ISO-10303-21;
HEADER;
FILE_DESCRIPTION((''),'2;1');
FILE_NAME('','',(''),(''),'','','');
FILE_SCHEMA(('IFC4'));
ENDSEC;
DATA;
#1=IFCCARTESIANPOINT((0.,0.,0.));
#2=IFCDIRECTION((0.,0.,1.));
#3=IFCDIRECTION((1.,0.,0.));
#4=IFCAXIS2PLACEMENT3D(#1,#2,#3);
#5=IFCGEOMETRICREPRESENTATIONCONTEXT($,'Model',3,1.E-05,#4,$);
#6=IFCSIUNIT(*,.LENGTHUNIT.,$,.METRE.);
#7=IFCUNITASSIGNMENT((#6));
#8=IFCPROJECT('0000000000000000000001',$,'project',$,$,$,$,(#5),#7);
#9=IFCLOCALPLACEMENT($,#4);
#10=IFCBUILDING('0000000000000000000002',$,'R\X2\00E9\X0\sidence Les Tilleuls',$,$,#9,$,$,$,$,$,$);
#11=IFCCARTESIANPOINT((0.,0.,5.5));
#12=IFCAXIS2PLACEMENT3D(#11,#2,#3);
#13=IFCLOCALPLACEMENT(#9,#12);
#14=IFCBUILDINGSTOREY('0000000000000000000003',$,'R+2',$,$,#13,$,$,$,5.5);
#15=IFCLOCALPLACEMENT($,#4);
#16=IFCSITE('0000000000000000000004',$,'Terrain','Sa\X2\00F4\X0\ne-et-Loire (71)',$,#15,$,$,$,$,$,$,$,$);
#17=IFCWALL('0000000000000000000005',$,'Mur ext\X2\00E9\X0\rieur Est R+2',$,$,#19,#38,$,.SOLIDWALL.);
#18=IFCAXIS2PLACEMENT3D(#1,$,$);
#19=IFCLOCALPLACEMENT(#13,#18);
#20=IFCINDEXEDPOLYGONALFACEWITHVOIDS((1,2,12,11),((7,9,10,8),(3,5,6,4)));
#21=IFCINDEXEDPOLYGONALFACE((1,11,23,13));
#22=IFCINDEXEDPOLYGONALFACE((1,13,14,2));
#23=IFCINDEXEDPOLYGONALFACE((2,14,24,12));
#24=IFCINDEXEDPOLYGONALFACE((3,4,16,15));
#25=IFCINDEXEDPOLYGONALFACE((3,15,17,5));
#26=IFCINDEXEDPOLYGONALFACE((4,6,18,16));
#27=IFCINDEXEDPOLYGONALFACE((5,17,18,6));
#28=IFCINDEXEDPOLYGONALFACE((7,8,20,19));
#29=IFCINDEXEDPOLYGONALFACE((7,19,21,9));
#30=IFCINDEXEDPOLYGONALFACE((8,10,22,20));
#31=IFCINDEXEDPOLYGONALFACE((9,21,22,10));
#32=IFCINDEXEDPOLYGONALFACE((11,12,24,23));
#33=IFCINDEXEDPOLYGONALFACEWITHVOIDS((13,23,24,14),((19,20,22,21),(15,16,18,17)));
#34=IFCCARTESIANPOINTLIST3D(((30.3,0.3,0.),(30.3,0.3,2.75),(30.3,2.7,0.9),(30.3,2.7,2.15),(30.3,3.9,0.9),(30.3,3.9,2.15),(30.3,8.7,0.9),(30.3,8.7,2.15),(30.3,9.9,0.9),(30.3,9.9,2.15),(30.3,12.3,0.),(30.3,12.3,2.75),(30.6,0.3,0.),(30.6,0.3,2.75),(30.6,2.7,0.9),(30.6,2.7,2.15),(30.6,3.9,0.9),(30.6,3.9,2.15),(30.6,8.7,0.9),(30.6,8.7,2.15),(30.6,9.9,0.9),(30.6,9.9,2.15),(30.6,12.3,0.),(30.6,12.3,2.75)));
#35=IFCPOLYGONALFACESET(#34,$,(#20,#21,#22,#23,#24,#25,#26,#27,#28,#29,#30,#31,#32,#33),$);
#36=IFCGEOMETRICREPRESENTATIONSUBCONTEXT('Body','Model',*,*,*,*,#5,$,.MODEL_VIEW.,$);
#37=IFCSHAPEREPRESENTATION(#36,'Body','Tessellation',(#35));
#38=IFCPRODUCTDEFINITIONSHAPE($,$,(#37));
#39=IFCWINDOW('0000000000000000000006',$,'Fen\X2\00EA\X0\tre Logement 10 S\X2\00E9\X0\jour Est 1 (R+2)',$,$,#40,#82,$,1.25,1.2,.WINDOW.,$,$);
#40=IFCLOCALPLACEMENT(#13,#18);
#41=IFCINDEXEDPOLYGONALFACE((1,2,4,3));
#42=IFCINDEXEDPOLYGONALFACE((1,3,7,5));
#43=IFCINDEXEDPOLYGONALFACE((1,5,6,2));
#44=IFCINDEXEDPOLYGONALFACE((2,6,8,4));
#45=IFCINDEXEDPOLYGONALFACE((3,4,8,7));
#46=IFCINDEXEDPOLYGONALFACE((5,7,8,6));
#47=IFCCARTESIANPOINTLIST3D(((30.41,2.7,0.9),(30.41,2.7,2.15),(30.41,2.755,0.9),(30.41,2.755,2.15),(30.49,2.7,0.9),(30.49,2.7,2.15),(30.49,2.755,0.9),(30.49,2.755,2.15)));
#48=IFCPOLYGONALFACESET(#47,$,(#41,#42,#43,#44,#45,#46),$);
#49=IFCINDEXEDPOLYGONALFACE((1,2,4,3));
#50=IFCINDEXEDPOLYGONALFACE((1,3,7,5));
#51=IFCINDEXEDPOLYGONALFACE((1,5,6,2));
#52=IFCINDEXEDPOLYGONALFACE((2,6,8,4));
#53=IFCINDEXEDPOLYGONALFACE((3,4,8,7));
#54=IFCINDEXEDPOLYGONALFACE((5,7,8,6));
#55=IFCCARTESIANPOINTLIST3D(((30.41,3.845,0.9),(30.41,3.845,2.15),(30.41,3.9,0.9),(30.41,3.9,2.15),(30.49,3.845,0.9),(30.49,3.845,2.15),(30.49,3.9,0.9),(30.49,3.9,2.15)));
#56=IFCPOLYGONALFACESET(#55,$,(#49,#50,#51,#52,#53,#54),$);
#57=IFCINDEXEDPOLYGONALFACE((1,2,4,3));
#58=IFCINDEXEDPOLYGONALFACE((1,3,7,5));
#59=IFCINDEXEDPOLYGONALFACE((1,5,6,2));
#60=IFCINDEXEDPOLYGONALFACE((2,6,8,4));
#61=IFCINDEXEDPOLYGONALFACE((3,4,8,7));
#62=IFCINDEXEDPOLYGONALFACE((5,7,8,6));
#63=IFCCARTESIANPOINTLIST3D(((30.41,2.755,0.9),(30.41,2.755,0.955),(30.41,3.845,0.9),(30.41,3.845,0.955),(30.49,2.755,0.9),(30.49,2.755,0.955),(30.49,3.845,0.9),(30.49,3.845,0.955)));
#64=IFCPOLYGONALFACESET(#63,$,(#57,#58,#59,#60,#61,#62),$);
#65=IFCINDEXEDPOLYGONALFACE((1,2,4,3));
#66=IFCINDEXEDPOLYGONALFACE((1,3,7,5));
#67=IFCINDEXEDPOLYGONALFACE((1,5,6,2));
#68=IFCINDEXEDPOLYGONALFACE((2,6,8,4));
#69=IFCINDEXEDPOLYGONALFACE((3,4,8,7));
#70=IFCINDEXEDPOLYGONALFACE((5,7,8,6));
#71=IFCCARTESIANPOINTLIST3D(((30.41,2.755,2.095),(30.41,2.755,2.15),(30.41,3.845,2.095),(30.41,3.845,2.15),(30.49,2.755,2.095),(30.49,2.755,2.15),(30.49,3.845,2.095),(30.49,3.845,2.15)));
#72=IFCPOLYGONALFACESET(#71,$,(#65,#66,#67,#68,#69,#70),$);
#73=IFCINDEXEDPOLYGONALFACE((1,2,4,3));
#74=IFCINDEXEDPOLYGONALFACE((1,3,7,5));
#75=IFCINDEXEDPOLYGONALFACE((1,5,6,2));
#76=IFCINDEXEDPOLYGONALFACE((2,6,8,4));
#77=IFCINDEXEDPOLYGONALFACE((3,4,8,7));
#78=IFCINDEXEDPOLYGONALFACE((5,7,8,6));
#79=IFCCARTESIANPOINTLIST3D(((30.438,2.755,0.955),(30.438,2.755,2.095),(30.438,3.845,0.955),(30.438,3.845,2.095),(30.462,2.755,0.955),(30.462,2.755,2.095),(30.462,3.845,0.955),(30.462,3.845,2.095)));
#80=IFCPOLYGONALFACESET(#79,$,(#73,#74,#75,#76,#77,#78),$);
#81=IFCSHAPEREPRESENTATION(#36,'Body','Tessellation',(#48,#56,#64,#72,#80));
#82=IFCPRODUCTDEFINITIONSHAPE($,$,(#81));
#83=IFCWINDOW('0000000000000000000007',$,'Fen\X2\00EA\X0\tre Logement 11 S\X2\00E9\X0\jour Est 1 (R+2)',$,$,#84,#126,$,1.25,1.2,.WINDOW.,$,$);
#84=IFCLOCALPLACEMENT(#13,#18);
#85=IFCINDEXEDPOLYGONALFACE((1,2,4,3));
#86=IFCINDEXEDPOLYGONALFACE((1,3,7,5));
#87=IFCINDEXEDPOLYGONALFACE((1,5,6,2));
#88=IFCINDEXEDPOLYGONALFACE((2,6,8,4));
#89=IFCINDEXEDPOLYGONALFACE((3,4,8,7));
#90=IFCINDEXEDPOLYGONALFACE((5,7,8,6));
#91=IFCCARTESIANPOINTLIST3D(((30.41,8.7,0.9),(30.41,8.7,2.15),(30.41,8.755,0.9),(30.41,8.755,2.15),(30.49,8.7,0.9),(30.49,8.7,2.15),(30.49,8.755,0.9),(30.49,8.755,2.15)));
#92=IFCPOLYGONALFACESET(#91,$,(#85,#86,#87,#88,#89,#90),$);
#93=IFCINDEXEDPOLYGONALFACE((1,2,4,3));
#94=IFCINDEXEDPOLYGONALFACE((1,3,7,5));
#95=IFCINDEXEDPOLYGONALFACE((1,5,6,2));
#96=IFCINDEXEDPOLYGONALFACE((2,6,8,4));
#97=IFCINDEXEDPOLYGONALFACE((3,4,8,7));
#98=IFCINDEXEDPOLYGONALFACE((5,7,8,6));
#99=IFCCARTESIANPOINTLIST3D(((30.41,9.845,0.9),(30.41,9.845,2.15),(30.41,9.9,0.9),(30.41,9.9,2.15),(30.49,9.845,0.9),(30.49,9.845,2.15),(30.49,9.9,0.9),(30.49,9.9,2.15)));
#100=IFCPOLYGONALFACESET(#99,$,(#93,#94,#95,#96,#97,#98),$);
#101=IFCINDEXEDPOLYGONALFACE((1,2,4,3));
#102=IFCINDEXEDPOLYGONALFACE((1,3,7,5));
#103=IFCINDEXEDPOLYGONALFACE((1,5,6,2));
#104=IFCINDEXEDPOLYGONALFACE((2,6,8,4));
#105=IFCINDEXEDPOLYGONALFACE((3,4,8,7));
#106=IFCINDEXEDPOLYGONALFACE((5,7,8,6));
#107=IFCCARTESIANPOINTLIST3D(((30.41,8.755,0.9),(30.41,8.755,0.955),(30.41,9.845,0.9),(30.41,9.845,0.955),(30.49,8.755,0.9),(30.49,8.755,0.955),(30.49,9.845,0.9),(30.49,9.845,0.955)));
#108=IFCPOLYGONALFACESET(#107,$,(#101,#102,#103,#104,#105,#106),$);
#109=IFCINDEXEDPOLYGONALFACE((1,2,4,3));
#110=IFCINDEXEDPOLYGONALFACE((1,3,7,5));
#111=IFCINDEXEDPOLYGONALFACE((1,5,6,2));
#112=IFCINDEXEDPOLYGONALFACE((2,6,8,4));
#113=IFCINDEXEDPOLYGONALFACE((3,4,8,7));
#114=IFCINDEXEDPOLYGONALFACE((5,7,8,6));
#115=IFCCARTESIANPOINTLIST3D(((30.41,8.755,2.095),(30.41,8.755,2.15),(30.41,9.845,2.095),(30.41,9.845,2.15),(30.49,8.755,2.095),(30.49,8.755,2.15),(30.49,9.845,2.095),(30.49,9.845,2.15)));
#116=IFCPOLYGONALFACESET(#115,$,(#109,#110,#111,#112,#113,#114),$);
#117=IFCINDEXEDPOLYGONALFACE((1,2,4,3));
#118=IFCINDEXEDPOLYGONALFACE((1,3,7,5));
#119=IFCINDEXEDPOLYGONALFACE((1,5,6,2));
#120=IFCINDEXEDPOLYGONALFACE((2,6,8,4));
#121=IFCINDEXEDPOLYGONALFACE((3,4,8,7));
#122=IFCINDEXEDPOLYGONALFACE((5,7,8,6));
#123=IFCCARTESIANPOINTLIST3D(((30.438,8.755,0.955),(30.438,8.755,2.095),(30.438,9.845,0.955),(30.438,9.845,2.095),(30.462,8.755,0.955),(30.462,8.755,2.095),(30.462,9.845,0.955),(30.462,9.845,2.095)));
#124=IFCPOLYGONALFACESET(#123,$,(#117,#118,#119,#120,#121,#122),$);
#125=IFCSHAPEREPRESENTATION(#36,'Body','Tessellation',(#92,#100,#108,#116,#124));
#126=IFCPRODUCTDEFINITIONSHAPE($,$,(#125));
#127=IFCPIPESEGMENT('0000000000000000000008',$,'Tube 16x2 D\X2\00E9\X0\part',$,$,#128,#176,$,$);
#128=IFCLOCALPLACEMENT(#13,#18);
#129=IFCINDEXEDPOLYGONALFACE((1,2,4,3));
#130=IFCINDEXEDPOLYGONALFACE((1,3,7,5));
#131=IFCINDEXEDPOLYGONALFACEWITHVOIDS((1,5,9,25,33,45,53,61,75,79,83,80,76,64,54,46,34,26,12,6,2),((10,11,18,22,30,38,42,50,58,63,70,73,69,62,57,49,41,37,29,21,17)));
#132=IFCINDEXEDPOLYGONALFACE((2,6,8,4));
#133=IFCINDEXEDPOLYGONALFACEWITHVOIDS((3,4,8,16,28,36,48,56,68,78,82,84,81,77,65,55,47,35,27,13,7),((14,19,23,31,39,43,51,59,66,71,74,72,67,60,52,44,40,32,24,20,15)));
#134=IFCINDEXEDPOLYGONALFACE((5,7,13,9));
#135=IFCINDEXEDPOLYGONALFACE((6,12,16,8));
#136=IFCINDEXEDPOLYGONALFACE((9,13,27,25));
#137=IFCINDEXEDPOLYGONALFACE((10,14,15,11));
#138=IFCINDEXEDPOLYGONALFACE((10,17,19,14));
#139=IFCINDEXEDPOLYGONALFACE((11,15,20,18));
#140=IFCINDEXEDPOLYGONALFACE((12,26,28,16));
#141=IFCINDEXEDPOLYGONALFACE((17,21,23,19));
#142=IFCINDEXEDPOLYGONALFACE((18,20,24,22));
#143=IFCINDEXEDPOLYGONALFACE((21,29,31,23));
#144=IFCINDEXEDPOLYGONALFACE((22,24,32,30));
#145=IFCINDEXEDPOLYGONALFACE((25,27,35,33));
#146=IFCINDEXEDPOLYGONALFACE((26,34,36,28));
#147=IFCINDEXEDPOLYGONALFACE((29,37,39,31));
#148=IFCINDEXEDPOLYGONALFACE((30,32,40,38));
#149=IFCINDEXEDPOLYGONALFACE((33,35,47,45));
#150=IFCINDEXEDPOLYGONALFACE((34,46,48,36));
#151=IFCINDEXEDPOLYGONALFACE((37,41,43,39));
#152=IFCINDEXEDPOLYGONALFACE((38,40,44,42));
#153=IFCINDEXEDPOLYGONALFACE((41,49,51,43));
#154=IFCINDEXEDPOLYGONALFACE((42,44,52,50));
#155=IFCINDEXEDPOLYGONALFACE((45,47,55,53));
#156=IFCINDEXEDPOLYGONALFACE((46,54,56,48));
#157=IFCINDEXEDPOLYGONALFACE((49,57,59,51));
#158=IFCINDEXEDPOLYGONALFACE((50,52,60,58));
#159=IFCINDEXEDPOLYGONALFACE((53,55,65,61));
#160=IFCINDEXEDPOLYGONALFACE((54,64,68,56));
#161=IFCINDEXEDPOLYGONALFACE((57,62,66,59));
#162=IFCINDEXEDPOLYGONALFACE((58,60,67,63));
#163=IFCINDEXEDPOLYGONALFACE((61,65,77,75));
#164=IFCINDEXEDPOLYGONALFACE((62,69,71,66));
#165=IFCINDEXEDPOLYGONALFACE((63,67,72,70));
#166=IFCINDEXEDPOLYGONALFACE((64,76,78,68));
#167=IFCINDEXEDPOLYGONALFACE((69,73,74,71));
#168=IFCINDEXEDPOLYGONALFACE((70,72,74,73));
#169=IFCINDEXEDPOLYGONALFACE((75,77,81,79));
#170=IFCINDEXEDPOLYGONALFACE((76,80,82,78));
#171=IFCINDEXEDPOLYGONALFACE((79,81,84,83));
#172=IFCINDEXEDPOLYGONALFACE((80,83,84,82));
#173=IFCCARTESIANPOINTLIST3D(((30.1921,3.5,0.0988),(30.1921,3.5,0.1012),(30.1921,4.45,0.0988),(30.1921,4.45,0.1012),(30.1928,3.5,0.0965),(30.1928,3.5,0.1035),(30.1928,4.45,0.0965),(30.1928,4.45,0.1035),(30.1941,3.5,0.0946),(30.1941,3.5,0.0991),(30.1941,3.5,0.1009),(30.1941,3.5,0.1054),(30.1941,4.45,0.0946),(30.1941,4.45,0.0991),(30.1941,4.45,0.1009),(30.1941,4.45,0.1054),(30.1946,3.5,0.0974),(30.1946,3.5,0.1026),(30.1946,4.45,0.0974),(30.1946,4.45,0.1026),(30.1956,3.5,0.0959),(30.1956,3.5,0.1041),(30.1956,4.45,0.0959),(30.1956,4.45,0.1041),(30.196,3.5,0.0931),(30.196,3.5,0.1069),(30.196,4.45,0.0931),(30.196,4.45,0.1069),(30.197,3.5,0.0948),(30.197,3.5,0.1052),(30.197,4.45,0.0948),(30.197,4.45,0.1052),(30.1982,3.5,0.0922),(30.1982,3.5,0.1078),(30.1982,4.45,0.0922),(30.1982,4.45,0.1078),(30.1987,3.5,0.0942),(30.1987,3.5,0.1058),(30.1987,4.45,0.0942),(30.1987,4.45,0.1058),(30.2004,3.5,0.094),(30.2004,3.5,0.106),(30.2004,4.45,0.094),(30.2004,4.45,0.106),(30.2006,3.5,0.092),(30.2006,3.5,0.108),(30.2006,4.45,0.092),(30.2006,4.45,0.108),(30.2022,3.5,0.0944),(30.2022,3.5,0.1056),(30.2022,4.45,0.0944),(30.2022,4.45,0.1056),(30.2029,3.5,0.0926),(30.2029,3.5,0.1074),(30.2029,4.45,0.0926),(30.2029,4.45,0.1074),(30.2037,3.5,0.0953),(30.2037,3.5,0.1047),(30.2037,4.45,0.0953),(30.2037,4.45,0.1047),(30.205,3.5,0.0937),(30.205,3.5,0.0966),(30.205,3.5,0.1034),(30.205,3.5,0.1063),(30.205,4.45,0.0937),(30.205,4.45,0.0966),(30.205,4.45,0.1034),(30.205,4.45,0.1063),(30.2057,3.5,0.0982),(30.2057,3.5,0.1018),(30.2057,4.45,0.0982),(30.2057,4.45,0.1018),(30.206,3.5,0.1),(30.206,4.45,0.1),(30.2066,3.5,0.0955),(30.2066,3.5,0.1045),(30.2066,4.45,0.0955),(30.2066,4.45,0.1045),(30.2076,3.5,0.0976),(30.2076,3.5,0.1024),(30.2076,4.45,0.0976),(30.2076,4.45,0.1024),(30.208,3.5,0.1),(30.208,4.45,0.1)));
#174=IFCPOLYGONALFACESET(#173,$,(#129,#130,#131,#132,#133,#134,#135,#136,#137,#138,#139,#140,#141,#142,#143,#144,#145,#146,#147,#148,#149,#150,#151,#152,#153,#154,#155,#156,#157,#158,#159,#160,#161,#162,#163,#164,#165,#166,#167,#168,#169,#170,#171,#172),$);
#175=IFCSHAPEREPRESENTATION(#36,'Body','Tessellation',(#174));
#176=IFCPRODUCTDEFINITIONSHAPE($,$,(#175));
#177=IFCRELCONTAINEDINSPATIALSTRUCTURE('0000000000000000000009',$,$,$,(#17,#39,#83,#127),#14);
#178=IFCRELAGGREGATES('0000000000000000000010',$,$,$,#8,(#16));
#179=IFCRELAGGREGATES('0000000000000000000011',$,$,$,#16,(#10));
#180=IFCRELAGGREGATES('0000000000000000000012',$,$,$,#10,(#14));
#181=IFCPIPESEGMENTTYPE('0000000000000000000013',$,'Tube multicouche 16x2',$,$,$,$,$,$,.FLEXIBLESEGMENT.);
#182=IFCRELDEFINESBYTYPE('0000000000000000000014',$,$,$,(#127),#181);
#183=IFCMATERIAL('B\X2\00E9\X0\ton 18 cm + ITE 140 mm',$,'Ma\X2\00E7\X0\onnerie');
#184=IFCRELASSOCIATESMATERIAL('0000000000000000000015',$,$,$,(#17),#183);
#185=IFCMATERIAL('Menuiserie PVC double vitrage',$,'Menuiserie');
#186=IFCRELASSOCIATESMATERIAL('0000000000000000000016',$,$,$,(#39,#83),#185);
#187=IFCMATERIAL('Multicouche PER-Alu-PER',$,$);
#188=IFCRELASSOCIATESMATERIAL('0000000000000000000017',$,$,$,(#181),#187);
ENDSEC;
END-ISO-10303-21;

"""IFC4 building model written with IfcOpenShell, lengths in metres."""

from ifc_helpers import new_model, si_unit, frame, frame_2d, origin_with_axes, place, context, subcontext, project, spatial, rectangle, hollow_circle, extrude, material, type_object, element, fill, save


model = new_model("IFC4")

# Units and contexts
model_context = context("Model", 3, precision=1e-05, world=origin_with_axes())
body_context = subcontext(model_context, "Body", "Model", "MODEL_VIEW")
ifc_project = project(units=[si_unit("LENGTHUNIT", "METRE")], contexts=[model_context])

# Site, building, storey
site_placement = place(None, origin_with_axes())
site = spatial("IfcSite", under=ifc_project, at=site_placement, Name="Terrain", Description="Saône-et-Loire (71)")
building_placement = place(None, origin_with_axes())
building = spatial("IfcBuilding", under=site, at=building_placement, Name="Résidence Les Tilleuls")
storey_placement = place(building_placement, frame((0.0, 0.0, 5.5), z_axis=(0.0, 0.0, 1.0), x_axis=(1.0, 0.0, 0.0)))
storey = spatial("IfcBuildingStorey", under=building, at=storey_placement, Name="R+2", Elevation=5.5)

# Wall, openings, windows
ifc_material_1 = material(Name="Béton 18 cm + ITE 140 mm", Category="Maçonnerie")
wall_placement = place(storey_placement, frame((30.3, 0.3, 0.0), z_axis=(0.0, 0.0, 1.0), x_axis=(1.0, 0.0, 0.0)))
wall = element("IfcWall", 1, at=wall_placement, inside=storey, material=ifc_material_1, Name="Mur extérieur Est R+2", PredefinedType="SOLIDWALL", context=body_context, shape_type="SweptSolid", body=[
    extrude(rectangle(XDim=0.3, YDim=12.0, at=frame_2d((0.15, 6.0))), origin_with_axes(), (0.0, 0.0, 1.0), 2.75),
])
opening_1_placement = place(storey_placement, frame((30.25, 2.7, 0.9), z_axis=(0.0, 0.0, 1.0), x_axis=(1.0, 0.0, 0.0)))
opening_1 = element("IfcOpeningElement", 2, at=opening_1_placement, cuts=wall, context=body_context, shape_type="SweptSolid", body=[
    extrude(rectangle(XDim=0.4, YDim=1.2, at=frame_2d((0.2, 0.6))), origin_with_axes(), (0.0, 0.0, 1.0), 1.25),
])
opening_2_placement = place(storey_placement, frame((30.25, 8.7, 0.9), z_axis=(0.0, 0.0, 1.0), x_axis=(1.0, 0.0, 0.0)))
opening_2 = element("IfcOpeningElement", 3, at=opening_2_placement, cuts=wall, context=body_context, shape_type="SweptSolid", body=[
    extrude(rectangle(XDim=0.4, YDim=1.2, at=frame_2d((0.2, 0.6))), origin_with_axes(), (0.0, 0.0, 1.0), 1.25),
])
ifc_material_2 = material(Name="Menuiserie PVC double vitrage", Category="Menuiserie")
window_1_placement = place(storey_placement, frame((30.41, 2.7, 0.9), z_axis=(0.0, 0.0, 1.0), x_axis=(1.0, 0.0, 0.0)))
window_1 = element("IfcWindow", 4, at=window_1_placement, inside=storey, material=ifc_material_2, Name="Fenêtre Logement 10 Séjour Est 1 (R+2)", OverallHeight=1.25, OverallWidth=1.2, PredefinedType="WINDOW", context=body_context, shape_type="SweptSolid", body=[
    extrude(rectangle(XDim=0.08, YDim=0.055, at=frame_2d((0.04, 0.0275))), origin_with_axes(), (0.0, 0.0, 1.0), 1.25),
    extrude(rectangle(XDim=0.08, YDim=0.055, at=frame_2d((0.04, 0.0275))), frame((0.0, 1.145, 0.0), z_axis=(0.0, 0.0, 1.0), x_axis=(1.0, 0.0, 0.0)), (0.0, 0.0, 1.0), 1.25),
    extrude(rectangle(XDim=0.08, YDim=1.09, at=frame_2d((0.04, 0.545))), frame((0.0, 0.055, 0.0), z_axis=(0.0, 0.0, 1.0), x_axis=(1.0, 0.0, 0.0)), (0.0, 0.0, 1.0), 0.055),
    extrude(rectangle(XDim=0.08, YDim=1.09, at=frame_2d((0.04, 0.545))), frame((0.0, 0.055, 1.195), z_axis=(0.0, 0.0, 1.0), x_axis=(1.0, 0.0, 0.0)), (0.0, 0.0, 1.0), 0.055),
    extrude(rectangle(XDim=0.024, YDim=1.09, at=frame_2d((0.012, 0.545))), frame((0.028, 0.055, 0.055), z_axis=(0.0, 0.0, 1.0), x_axis=(1.0, 0.0, 0.0)), (0.0, 0.0, 1.0), 1.14),
])
fill(opening_1, window_1)
window_2_placement = place(storey_placement, frame((30.41, 8.7, 0.9), z_axis=(0.0, 0.0, 1.0), x_axis=(1.0, 0.0, 0.0)))
window_2 = element("IfcWindow", 5, at=window_2_placement, inside=storey, material=ifc_material_2, Name="Fenêtre Logement 11 Séjour Est 1 (R+2)", OverallHeight=1.25, OverallWidth=1.2, PredefinedType="WINDOW", context=body_context, shape_type="SweptSolid", body=[
    extrude(rectangle(XDim=0.08, YDim=0.055, at=frame_2d((0.04, 0.0275))), origin_with_axes(), (0.0, 0.0, 1.0), 1.25),
    extrude(rectangle(XDim=0.08, YDim=0.055, at=frame_2d((0.04, 0.0275))), frame((0.0, 1.145, 0.0), z_axis=(0.0, 0.0, 1.0), x_axis=(1.0, 0.0, 0.0)), (0.0, 0.0, 1.0), 1.25),
    extrude(rectangle(XDim=0.08, YDim=1.09, at=frame_2d((0.04, 0.545))), frame((0.0, 0.055, 0.0), z_axis=(0.0, 0.0, 1.0), x_axis=(1.0, 0.0, 0.0)), (0.0, 0.0, 1.0), 0.055),
    extrude(rectangle(XDim=0.08, YDim=1.09, at=frame_2d((0.04, 0.545))), frame((0.0, 0.055, 1.195), z_axis=(0.0, 0.0, 1.0), x_axis=(1.0, 0.0, 0.0)), (0.0, 0.0, 1.0), 0.055),
    extrude(rectangle(XDim=0.024, YDim=1.09, at=frame_2d((0.012, 0.545))), frame((0.028, 0.055, 0.055), z_axis=(0.0, 0.0, 1.0), x_axis=(1.0, 0.0, 0.0)), (0.0, 0.0, 1.0), 1.14),
])
fill(opening_2, window_2)

# Pipe segment
ifc_material_3 = material(Name="Multicouche PER-Alu-PER")
pipe_segment_type_1 = type_object("IfcPipeSegmentType", Name="Tube multicouche 16x2", PredefinedType="FLEXIBLESEGMENT", material=ifc_material_3)
pipe_segment_1_placement = place(storey_placement, frame((30.2, 4.45, 0.1), z_axis=(0.0, -1.0, 0.0), x_axis=(1.0, 0.0, 0.0)))
element("IfcPipeSegment", 6, at=pipe_segment_1_placement, inside=storey, type_object=pipe_segment_type_1, Name="Tube 16x2 Départ", context=body_context, shape_type="SweptSolid", body=[
    extrude(hollow_circle(Radius=0.008, WallThickness=0.002), origin_with_axes(), (0.0, 0.0, 1.0), 0.95),
])

save(model, "model.ifc")
